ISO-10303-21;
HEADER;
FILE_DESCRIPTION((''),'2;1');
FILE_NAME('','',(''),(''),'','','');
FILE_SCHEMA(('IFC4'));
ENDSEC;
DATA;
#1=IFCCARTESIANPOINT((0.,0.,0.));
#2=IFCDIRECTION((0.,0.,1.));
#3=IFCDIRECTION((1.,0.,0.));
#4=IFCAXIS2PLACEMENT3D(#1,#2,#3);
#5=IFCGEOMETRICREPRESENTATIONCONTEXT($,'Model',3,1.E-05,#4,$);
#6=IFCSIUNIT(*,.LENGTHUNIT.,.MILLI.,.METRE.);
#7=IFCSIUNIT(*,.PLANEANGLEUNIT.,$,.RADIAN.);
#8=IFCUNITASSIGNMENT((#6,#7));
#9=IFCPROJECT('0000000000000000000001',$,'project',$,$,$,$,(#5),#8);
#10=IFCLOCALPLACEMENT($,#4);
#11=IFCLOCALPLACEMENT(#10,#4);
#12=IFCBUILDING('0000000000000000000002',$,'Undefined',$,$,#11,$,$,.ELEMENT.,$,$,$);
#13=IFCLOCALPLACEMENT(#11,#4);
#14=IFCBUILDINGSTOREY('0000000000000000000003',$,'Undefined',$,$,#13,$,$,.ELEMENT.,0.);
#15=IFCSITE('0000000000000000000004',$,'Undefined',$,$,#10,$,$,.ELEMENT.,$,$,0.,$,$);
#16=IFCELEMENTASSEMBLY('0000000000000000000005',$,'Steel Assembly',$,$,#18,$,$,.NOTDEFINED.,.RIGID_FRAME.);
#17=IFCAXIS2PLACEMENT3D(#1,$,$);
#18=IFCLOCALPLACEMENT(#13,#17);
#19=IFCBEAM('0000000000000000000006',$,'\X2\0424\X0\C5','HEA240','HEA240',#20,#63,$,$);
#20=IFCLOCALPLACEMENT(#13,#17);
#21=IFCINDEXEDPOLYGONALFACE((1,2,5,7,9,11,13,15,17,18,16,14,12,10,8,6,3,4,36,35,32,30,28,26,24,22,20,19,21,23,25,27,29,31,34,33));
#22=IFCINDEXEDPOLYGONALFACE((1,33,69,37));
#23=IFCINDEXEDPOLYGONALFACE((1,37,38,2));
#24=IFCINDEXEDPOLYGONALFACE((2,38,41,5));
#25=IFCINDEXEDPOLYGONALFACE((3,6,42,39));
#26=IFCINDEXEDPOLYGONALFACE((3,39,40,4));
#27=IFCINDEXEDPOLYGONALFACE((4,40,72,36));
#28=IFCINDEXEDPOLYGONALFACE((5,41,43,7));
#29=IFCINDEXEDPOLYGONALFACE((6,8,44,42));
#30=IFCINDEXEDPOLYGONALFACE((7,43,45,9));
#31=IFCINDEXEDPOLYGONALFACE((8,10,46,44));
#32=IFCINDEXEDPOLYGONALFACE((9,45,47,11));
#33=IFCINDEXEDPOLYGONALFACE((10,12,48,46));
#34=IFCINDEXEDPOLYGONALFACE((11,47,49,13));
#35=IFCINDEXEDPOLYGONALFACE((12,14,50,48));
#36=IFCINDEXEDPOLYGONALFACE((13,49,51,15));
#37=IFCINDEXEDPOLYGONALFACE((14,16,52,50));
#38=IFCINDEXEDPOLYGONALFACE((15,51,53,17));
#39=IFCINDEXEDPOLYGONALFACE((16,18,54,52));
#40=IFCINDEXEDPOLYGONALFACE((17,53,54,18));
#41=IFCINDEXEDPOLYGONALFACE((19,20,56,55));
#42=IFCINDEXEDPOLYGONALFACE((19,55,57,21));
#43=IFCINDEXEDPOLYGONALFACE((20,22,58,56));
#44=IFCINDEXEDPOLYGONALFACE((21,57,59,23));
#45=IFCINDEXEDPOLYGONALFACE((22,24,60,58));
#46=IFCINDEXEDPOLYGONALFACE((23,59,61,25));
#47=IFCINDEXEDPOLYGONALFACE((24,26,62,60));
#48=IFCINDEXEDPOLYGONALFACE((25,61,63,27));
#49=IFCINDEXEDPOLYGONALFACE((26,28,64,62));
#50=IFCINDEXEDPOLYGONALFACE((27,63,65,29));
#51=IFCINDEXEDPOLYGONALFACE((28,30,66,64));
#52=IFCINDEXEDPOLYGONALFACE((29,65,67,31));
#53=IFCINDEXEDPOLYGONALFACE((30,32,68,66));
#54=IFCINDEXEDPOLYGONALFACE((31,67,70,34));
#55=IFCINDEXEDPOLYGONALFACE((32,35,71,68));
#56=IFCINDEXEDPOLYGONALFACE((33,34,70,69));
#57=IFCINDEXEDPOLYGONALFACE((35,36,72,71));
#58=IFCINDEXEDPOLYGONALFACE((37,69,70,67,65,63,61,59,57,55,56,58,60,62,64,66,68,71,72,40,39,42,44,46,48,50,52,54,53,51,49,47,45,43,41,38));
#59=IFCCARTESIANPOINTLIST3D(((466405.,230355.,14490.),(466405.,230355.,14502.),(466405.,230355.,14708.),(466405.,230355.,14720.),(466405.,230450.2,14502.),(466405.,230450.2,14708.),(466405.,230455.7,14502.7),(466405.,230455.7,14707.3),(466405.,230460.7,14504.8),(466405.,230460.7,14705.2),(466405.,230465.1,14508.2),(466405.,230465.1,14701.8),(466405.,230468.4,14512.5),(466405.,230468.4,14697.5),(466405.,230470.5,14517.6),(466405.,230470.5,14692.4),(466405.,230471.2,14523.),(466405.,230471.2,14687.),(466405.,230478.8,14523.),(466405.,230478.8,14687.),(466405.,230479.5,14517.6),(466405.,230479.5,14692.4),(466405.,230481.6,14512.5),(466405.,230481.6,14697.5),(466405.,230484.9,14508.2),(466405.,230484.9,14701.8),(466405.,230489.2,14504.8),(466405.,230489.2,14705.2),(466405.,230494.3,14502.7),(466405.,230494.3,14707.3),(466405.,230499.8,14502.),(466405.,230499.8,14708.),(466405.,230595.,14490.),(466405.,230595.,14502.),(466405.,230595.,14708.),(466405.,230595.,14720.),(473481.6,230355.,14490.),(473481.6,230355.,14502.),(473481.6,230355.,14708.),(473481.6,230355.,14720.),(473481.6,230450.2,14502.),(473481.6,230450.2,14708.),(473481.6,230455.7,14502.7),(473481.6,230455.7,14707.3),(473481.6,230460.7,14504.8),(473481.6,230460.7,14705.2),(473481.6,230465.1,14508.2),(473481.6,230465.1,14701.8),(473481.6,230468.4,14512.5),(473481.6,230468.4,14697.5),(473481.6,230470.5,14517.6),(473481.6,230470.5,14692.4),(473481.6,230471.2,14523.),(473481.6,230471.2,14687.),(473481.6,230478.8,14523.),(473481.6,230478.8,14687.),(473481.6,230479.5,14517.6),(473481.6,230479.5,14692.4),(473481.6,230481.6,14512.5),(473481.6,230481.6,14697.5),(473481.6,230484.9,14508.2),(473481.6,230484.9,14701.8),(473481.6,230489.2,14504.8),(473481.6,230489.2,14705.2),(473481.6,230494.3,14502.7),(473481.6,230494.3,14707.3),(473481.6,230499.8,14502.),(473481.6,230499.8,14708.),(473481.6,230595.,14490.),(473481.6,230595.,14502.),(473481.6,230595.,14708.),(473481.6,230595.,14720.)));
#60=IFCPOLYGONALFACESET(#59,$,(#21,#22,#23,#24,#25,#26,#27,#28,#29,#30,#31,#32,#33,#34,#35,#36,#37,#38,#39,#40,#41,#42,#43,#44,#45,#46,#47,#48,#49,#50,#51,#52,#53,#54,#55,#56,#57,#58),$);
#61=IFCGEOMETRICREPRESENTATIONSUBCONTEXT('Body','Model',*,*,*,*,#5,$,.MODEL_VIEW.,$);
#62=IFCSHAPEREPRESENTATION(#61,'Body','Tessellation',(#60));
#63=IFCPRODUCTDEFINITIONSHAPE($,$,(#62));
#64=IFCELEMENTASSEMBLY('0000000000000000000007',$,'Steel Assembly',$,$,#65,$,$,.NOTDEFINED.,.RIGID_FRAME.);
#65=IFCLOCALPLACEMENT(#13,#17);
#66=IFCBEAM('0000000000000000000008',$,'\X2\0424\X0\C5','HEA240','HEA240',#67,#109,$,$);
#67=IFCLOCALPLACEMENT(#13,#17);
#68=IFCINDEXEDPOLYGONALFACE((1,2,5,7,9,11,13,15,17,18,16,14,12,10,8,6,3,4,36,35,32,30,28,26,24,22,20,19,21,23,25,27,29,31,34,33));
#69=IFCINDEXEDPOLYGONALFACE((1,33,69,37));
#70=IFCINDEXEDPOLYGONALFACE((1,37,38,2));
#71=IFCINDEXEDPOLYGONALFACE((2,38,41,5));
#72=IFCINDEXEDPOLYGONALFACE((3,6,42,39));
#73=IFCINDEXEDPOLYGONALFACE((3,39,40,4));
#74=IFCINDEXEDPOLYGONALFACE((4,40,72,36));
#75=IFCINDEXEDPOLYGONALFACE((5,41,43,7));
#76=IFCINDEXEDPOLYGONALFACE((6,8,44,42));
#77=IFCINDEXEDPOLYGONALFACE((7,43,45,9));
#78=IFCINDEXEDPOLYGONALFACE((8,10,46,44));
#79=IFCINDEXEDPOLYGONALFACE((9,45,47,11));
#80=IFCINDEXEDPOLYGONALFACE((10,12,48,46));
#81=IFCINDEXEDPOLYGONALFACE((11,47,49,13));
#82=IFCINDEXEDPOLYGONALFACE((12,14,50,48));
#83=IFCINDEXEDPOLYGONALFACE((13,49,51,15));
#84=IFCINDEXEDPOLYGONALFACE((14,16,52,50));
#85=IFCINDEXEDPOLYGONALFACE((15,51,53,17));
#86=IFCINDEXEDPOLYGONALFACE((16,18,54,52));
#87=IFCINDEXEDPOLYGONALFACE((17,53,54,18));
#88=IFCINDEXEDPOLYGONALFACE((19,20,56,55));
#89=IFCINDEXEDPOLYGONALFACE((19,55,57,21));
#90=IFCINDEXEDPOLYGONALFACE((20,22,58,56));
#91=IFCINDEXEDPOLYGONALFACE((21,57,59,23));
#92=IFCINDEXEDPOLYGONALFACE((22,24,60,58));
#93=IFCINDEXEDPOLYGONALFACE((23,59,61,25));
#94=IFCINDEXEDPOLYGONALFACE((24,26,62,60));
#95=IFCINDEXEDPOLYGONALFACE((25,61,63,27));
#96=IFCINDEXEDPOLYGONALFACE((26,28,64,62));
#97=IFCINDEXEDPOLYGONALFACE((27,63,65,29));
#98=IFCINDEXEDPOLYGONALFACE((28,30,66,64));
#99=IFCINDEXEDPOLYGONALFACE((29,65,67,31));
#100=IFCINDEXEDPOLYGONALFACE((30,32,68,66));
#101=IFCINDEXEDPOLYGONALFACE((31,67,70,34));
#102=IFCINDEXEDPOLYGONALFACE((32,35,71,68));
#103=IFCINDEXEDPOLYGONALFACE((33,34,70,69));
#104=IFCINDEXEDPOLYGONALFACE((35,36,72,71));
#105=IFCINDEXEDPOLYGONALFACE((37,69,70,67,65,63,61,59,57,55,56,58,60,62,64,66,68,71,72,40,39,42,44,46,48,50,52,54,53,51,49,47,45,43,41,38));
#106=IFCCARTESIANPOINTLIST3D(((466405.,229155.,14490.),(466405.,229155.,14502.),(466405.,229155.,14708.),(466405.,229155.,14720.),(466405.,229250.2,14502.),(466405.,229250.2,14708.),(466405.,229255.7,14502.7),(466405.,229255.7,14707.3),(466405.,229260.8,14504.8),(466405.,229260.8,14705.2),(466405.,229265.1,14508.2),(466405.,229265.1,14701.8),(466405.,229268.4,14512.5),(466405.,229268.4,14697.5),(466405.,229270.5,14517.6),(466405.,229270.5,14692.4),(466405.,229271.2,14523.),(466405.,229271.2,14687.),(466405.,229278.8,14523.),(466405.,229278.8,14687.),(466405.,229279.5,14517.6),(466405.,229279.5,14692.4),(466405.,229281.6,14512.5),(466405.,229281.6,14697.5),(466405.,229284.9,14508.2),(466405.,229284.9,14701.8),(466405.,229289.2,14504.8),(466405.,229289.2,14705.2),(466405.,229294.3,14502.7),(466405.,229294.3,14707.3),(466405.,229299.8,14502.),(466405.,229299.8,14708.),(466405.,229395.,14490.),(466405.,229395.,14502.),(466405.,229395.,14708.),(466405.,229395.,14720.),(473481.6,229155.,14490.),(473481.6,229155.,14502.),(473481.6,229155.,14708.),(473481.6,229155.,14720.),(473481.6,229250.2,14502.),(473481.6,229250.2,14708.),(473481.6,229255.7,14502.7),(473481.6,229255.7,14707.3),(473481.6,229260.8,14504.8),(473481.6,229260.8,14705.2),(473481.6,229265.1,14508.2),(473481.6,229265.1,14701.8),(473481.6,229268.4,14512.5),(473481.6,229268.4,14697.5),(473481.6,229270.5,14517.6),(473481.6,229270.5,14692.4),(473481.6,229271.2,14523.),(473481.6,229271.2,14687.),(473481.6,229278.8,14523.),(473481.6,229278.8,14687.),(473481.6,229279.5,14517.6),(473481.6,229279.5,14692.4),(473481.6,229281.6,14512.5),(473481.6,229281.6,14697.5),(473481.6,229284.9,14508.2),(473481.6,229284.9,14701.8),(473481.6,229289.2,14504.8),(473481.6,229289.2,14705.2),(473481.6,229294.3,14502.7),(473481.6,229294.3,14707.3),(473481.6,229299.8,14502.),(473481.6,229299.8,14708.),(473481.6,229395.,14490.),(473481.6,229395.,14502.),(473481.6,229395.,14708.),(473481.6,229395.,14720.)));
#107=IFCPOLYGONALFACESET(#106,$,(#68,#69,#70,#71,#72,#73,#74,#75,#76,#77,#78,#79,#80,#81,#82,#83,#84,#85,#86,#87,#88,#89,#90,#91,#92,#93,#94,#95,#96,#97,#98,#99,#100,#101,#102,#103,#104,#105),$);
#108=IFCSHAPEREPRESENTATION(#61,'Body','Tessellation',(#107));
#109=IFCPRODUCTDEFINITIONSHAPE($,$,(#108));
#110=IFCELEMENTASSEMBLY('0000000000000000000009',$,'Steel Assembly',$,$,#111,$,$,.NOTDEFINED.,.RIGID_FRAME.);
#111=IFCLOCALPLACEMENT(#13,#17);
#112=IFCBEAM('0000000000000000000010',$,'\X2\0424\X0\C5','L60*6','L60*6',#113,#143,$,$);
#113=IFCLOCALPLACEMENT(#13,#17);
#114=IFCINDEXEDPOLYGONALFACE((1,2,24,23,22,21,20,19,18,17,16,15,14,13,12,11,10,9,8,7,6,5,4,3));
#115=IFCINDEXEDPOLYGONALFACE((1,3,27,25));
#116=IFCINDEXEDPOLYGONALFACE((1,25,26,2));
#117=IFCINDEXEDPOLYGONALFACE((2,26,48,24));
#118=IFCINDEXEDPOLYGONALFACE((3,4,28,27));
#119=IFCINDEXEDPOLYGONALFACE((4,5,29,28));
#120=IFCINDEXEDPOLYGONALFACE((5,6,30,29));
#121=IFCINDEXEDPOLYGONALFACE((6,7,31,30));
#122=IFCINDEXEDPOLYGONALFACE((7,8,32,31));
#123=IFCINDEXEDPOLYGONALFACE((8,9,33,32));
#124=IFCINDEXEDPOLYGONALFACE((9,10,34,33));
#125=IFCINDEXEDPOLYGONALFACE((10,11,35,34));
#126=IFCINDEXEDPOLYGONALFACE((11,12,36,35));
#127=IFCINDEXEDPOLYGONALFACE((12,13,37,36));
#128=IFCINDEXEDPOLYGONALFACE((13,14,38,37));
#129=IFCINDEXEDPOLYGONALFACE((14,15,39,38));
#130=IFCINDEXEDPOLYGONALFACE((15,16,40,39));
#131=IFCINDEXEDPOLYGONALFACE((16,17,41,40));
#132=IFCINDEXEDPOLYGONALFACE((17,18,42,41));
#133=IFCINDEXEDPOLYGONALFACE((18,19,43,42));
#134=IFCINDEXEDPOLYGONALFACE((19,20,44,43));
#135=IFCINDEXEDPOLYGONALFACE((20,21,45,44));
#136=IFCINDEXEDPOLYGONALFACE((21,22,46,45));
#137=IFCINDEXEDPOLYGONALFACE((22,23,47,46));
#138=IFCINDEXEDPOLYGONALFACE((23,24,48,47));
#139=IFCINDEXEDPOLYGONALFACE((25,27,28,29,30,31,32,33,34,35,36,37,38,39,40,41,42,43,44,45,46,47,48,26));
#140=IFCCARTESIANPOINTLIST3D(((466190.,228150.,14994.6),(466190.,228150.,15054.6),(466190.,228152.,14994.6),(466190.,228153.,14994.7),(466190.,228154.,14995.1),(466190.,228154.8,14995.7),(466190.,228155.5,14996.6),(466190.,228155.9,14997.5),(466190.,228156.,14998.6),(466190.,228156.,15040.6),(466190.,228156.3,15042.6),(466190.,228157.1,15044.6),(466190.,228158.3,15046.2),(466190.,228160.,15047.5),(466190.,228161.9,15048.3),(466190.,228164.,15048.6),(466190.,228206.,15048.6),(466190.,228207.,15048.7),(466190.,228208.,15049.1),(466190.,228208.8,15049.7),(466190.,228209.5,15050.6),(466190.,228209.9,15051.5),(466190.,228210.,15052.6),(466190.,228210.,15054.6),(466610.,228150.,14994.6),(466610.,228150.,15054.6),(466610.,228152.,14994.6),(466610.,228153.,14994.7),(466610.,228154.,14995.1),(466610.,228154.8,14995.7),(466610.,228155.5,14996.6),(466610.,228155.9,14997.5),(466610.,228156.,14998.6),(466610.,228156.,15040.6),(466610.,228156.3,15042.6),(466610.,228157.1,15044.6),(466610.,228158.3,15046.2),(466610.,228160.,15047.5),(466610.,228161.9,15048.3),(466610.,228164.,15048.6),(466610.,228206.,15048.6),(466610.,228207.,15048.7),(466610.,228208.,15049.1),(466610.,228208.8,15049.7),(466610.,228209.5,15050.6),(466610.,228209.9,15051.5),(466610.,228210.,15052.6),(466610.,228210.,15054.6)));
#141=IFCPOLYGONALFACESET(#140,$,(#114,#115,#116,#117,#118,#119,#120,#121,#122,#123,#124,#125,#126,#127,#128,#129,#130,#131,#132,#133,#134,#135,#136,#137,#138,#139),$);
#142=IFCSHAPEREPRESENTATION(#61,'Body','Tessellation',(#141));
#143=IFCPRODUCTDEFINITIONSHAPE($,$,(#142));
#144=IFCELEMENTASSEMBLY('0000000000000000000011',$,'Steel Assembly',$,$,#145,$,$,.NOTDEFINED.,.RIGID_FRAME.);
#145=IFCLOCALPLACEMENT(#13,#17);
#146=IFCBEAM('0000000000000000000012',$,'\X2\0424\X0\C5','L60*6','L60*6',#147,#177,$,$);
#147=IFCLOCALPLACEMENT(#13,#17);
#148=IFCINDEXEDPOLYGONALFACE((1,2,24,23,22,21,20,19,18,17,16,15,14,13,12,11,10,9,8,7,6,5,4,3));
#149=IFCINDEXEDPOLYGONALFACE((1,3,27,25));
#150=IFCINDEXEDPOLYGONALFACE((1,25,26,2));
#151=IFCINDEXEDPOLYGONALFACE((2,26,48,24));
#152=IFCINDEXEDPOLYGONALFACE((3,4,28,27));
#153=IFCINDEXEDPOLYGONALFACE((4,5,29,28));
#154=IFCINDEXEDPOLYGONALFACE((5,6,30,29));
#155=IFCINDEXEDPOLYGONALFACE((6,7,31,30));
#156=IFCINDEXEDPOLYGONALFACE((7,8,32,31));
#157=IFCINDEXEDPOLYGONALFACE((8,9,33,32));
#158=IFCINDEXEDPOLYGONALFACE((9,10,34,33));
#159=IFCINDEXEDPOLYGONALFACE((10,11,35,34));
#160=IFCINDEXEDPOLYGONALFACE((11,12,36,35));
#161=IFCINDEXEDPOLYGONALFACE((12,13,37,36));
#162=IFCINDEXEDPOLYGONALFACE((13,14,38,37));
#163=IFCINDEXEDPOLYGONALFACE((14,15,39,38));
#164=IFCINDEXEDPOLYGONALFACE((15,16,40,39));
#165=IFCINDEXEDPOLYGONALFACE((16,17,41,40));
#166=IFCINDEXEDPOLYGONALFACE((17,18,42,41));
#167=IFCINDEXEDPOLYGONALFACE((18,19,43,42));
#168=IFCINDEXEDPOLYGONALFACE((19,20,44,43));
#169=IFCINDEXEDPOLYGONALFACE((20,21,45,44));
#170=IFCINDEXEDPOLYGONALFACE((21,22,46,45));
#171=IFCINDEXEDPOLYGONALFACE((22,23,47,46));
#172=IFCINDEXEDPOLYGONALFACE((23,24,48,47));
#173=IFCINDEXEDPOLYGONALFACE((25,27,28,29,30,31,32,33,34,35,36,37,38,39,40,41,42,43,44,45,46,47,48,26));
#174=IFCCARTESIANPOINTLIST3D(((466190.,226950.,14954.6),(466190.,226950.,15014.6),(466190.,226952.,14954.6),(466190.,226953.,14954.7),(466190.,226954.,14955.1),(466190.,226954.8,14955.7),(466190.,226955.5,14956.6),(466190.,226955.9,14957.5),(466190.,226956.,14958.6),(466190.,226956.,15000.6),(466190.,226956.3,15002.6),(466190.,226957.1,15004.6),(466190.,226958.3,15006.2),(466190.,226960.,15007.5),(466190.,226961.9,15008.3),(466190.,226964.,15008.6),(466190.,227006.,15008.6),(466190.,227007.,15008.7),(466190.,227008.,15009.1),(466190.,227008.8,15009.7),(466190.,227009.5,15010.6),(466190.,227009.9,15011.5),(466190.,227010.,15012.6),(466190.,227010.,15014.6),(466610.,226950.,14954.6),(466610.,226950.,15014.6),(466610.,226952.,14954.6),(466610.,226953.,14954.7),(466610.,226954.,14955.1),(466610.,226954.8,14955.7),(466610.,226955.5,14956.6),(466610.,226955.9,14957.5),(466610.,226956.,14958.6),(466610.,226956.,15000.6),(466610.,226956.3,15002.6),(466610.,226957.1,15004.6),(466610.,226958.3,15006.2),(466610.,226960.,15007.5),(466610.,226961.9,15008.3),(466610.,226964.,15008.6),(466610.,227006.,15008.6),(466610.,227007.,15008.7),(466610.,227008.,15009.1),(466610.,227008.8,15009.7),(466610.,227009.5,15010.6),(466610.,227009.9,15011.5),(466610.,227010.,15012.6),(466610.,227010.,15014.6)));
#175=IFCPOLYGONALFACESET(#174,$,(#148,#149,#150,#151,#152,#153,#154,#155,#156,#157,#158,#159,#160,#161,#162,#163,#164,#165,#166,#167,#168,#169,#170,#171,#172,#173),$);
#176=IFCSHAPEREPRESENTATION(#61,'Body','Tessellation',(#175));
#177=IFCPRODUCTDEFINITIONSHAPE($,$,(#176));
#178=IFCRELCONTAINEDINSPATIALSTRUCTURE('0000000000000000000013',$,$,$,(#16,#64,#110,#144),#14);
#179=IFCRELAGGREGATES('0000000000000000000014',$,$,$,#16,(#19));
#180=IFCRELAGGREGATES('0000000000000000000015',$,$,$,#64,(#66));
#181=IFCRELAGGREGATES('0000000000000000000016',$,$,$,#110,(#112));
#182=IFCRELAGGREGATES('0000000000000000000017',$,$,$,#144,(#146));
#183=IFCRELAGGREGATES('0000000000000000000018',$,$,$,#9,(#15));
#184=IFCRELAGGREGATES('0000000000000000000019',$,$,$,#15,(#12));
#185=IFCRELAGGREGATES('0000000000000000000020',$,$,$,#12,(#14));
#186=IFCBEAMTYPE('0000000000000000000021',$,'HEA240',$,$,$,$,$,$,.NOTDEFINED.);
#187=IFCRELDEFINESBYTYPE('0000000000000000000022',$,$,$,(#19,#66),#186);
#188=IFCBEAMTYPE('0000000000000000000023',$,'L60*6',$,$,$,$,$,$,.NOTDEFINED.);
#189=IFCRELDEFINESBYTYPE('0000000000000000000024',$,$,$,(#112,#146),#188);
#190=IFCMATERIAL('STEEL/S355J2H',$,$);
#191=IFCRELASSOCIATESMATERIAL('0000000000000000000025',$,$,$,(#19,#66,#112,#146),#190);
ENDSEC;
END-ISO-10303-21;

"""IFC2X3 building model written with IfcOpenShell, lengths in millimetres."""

from ifc_helpers import new_model, si_unit, frame, origin_with_axes, origin_2d_with_axis, place, context, subcontext, project, spatial, i_section, l_section, extrude, material, type_object, element, aggregate, save


model = new_model("IFC2X3")

# Units and contexts
model_context = context("Model", 3, precision=1e-05, world=origin_with_axes())
body_context = subcontext(model_context, "Body", "Model", "MODEL_VIEW")
ifc_project = project(units=[si_unit("LENGTHUNIT", "METRE", prefix="MILLI"), si_unit("PLANEANGLEUNIT", "RADIAN")], contexts=[model_context])

# Site, building, storey
site_placement = place(None, origin_with_axes())
site = spatial("IfcSite", under=ifc_project, at=site_placement, Name="Undefined", CompositionType="ELEMENT", RefElevation=0.0)
building_placement = place(site_placement, origin_with_axes())
building = spatial("IfcBuilding", under=site, at=building_placement, Name="Undefined", CompositionType="ELEMENT")
storey_placement = place(building_placement, origin_with_axes())
storey = spatial("IfcBuildingStorey", under=building, at=storey_placement, Name="Undefined", CompositionType="ELEMENT", Elevation=0.0)

# Element assemblies, beams
assembly_1_placement = place(storey_placement, origin_with_axes())
assembly_1 = element("IfcElementAssembly", 1, at=assembly_1_placement, inside=storey, Name="Steel Assembly", AssemblyPlace="NOTDEFINED", PredefinedType="RIGID_FRAME")
ifc_material_1 = material(Name="STEEL/S355J2H")
beam_type_1 = type_object("IfcBeamType", Name="HEA240", PredefinedType="NOTDEFINED")
beam_1_placement = place(assembly_1_placement, frame((466405.0, 230475.0, 14605.0), z_axis=(0.0, 0.0, 1.0), x_axis=(1.0, 0.0, 0.0)))
beam_1 = element("IfcBeam", 2, at=beam_1_placement, type_object=beam_type_1, material=ifc_material_1, Name="ФC5", Description="HEA240", ObjectType="HEA240", context=body_context, shape_type="SweptSolid", body=[
    extrude(i_section(OverallWidth=240.0, OverallDepth=230.0, WebThickness=7.5, FlangeThickness=12.0, FilletRadius=21.0, at=origin_2d_with_axis()), frame((7076.6, 0.0, 0.0), z_axis=(-1.0, 0.0, 0.0), x_axis=(0.0, -1.0, 0.0)), (0.0, 0.0, 1.0), 7076.6),
])
aggregate(assembly_1, [beam_1])
assembly_2_placement = place(storey_placement, origin_with_axes())
assembly_2 = element("IfcElementAssembly", 3, at=assembly_2_placement, inside=storey, Name="Steel Assembly", AssemblyPlace="NOTDEFINED", PredefinedType="RIGID_FRAME")
beam_2_placement = place(assembly_2_placement, frame((466405.0, 229275.0, 14605.0), z_axis=(0.0, 0.0, 1.0), x_axis=(1.0, 0.0, 0.0)))
beam_2 = element("IfcBeam", 4, at=beam_2_placement, type_object=beam_type_1, material=ifc_material_1, Name="ФC5", Description="HEA240", ObjectType="HEA240", context=body_context, shape_type="SweptSolid", body=[
    extrude(i_section(OverallWidth=240.0, OverallDepth=230.0, WebThickness=7.5, FlangeThickness=12.0, FilletRadius=21.0, at=origin_2d_with_axis()), frame((7076.6, 0.0, 0.0), z_axis=(-1.0, 0.0, 0.0), x_axis=(0.0, -1.0, 0.0)), (0.0, 0.0, 1.0), 7076.6),
])
aggregate(assembly_2, [beam_2])
assembly_3_placement = place(storey_placement, origin_with_axes())
assembly_3 = element("IfcElementAssembly", 5, at=assembly_3_placement, inside=storey, Name="Steel Assembly", AssemblyPlace="NOTDEFINED", PredefinedType="RIGID_FRAME")
beam_type_2 = type_object("IfcBeamType", Name="L60*6", PredefinedType="NOTDEFINED")
beam_3_placement = place(assembly_3_placement, frame((466610.0, 228180.0, 15024.6), z_axis=(0.0, 1.0, 0.0), x_axis=(-1.0, 0.0, 0.0)))
beam_3 = element("IfcBeam", 6, at=beam_3_placement, type_object=beam_type_2, material=ifc_material_1, Name="ФC5", Description="L60*6", ObjectType="L60*6", context=body_context, shape_type="SweptSolid", body=[
    extrude(l_section(Depth=60.0, Width=60.0, Thickness=6.0, FilletRadius=8.0, EdgeRadius=4.0, at=origin_2d_with_axis()), frame((420.0, 0.0, 0.0), z_axis=(-1.0, 0.0, 0.0), x_axis=(0.0, -1.0, 0.0)), (0.0, 0.0, 1.0), 420.0),
])
aggregate(assembly_3, [beam_3])
assembly_4_placement = place(storey_placement, origin_with_axes())
assembly_4 = element("IfcElementAssembly", 7, at=assembly_4_placement, inside=storey, Name="Steel Assembly", AssemblyPlace="NOTDEFINED", PredefinedType="RIGID_FRAME")
beam_4_placement = place(assembly_4_placement, frame((466610.0, 226980.0, 14984.6), z_axis=(0.0, 1.0, 0.0), x_axis=(-1.0, 0.0, 0.0)))
beam_4 = element("IfcBeam", 8, at=beam_4_placement, type_object=beam_type_2, material=ifc_material_1, Name="ФC5", Description="L60*6", ObjectType="L60*6", context=body_context, shape_type="SweptSolid", body=[
    extrude(l_section(Depth=60.0, Width=60.0, Thickness=6.0, FilletRadius=8.0, EdgeRadius=4.0, at=origin_2d_with_axis()), frame((420.0, 0.0, 0.0), z_axis=(-1.0, 0.0, 0.0), x_axis=(0.0, -1.0, 0.0)), (0.0, 0.0, 1.0), 420.0),
])
aggregate(assembly_4, [beam_4])

save(model, "model.ifc")
